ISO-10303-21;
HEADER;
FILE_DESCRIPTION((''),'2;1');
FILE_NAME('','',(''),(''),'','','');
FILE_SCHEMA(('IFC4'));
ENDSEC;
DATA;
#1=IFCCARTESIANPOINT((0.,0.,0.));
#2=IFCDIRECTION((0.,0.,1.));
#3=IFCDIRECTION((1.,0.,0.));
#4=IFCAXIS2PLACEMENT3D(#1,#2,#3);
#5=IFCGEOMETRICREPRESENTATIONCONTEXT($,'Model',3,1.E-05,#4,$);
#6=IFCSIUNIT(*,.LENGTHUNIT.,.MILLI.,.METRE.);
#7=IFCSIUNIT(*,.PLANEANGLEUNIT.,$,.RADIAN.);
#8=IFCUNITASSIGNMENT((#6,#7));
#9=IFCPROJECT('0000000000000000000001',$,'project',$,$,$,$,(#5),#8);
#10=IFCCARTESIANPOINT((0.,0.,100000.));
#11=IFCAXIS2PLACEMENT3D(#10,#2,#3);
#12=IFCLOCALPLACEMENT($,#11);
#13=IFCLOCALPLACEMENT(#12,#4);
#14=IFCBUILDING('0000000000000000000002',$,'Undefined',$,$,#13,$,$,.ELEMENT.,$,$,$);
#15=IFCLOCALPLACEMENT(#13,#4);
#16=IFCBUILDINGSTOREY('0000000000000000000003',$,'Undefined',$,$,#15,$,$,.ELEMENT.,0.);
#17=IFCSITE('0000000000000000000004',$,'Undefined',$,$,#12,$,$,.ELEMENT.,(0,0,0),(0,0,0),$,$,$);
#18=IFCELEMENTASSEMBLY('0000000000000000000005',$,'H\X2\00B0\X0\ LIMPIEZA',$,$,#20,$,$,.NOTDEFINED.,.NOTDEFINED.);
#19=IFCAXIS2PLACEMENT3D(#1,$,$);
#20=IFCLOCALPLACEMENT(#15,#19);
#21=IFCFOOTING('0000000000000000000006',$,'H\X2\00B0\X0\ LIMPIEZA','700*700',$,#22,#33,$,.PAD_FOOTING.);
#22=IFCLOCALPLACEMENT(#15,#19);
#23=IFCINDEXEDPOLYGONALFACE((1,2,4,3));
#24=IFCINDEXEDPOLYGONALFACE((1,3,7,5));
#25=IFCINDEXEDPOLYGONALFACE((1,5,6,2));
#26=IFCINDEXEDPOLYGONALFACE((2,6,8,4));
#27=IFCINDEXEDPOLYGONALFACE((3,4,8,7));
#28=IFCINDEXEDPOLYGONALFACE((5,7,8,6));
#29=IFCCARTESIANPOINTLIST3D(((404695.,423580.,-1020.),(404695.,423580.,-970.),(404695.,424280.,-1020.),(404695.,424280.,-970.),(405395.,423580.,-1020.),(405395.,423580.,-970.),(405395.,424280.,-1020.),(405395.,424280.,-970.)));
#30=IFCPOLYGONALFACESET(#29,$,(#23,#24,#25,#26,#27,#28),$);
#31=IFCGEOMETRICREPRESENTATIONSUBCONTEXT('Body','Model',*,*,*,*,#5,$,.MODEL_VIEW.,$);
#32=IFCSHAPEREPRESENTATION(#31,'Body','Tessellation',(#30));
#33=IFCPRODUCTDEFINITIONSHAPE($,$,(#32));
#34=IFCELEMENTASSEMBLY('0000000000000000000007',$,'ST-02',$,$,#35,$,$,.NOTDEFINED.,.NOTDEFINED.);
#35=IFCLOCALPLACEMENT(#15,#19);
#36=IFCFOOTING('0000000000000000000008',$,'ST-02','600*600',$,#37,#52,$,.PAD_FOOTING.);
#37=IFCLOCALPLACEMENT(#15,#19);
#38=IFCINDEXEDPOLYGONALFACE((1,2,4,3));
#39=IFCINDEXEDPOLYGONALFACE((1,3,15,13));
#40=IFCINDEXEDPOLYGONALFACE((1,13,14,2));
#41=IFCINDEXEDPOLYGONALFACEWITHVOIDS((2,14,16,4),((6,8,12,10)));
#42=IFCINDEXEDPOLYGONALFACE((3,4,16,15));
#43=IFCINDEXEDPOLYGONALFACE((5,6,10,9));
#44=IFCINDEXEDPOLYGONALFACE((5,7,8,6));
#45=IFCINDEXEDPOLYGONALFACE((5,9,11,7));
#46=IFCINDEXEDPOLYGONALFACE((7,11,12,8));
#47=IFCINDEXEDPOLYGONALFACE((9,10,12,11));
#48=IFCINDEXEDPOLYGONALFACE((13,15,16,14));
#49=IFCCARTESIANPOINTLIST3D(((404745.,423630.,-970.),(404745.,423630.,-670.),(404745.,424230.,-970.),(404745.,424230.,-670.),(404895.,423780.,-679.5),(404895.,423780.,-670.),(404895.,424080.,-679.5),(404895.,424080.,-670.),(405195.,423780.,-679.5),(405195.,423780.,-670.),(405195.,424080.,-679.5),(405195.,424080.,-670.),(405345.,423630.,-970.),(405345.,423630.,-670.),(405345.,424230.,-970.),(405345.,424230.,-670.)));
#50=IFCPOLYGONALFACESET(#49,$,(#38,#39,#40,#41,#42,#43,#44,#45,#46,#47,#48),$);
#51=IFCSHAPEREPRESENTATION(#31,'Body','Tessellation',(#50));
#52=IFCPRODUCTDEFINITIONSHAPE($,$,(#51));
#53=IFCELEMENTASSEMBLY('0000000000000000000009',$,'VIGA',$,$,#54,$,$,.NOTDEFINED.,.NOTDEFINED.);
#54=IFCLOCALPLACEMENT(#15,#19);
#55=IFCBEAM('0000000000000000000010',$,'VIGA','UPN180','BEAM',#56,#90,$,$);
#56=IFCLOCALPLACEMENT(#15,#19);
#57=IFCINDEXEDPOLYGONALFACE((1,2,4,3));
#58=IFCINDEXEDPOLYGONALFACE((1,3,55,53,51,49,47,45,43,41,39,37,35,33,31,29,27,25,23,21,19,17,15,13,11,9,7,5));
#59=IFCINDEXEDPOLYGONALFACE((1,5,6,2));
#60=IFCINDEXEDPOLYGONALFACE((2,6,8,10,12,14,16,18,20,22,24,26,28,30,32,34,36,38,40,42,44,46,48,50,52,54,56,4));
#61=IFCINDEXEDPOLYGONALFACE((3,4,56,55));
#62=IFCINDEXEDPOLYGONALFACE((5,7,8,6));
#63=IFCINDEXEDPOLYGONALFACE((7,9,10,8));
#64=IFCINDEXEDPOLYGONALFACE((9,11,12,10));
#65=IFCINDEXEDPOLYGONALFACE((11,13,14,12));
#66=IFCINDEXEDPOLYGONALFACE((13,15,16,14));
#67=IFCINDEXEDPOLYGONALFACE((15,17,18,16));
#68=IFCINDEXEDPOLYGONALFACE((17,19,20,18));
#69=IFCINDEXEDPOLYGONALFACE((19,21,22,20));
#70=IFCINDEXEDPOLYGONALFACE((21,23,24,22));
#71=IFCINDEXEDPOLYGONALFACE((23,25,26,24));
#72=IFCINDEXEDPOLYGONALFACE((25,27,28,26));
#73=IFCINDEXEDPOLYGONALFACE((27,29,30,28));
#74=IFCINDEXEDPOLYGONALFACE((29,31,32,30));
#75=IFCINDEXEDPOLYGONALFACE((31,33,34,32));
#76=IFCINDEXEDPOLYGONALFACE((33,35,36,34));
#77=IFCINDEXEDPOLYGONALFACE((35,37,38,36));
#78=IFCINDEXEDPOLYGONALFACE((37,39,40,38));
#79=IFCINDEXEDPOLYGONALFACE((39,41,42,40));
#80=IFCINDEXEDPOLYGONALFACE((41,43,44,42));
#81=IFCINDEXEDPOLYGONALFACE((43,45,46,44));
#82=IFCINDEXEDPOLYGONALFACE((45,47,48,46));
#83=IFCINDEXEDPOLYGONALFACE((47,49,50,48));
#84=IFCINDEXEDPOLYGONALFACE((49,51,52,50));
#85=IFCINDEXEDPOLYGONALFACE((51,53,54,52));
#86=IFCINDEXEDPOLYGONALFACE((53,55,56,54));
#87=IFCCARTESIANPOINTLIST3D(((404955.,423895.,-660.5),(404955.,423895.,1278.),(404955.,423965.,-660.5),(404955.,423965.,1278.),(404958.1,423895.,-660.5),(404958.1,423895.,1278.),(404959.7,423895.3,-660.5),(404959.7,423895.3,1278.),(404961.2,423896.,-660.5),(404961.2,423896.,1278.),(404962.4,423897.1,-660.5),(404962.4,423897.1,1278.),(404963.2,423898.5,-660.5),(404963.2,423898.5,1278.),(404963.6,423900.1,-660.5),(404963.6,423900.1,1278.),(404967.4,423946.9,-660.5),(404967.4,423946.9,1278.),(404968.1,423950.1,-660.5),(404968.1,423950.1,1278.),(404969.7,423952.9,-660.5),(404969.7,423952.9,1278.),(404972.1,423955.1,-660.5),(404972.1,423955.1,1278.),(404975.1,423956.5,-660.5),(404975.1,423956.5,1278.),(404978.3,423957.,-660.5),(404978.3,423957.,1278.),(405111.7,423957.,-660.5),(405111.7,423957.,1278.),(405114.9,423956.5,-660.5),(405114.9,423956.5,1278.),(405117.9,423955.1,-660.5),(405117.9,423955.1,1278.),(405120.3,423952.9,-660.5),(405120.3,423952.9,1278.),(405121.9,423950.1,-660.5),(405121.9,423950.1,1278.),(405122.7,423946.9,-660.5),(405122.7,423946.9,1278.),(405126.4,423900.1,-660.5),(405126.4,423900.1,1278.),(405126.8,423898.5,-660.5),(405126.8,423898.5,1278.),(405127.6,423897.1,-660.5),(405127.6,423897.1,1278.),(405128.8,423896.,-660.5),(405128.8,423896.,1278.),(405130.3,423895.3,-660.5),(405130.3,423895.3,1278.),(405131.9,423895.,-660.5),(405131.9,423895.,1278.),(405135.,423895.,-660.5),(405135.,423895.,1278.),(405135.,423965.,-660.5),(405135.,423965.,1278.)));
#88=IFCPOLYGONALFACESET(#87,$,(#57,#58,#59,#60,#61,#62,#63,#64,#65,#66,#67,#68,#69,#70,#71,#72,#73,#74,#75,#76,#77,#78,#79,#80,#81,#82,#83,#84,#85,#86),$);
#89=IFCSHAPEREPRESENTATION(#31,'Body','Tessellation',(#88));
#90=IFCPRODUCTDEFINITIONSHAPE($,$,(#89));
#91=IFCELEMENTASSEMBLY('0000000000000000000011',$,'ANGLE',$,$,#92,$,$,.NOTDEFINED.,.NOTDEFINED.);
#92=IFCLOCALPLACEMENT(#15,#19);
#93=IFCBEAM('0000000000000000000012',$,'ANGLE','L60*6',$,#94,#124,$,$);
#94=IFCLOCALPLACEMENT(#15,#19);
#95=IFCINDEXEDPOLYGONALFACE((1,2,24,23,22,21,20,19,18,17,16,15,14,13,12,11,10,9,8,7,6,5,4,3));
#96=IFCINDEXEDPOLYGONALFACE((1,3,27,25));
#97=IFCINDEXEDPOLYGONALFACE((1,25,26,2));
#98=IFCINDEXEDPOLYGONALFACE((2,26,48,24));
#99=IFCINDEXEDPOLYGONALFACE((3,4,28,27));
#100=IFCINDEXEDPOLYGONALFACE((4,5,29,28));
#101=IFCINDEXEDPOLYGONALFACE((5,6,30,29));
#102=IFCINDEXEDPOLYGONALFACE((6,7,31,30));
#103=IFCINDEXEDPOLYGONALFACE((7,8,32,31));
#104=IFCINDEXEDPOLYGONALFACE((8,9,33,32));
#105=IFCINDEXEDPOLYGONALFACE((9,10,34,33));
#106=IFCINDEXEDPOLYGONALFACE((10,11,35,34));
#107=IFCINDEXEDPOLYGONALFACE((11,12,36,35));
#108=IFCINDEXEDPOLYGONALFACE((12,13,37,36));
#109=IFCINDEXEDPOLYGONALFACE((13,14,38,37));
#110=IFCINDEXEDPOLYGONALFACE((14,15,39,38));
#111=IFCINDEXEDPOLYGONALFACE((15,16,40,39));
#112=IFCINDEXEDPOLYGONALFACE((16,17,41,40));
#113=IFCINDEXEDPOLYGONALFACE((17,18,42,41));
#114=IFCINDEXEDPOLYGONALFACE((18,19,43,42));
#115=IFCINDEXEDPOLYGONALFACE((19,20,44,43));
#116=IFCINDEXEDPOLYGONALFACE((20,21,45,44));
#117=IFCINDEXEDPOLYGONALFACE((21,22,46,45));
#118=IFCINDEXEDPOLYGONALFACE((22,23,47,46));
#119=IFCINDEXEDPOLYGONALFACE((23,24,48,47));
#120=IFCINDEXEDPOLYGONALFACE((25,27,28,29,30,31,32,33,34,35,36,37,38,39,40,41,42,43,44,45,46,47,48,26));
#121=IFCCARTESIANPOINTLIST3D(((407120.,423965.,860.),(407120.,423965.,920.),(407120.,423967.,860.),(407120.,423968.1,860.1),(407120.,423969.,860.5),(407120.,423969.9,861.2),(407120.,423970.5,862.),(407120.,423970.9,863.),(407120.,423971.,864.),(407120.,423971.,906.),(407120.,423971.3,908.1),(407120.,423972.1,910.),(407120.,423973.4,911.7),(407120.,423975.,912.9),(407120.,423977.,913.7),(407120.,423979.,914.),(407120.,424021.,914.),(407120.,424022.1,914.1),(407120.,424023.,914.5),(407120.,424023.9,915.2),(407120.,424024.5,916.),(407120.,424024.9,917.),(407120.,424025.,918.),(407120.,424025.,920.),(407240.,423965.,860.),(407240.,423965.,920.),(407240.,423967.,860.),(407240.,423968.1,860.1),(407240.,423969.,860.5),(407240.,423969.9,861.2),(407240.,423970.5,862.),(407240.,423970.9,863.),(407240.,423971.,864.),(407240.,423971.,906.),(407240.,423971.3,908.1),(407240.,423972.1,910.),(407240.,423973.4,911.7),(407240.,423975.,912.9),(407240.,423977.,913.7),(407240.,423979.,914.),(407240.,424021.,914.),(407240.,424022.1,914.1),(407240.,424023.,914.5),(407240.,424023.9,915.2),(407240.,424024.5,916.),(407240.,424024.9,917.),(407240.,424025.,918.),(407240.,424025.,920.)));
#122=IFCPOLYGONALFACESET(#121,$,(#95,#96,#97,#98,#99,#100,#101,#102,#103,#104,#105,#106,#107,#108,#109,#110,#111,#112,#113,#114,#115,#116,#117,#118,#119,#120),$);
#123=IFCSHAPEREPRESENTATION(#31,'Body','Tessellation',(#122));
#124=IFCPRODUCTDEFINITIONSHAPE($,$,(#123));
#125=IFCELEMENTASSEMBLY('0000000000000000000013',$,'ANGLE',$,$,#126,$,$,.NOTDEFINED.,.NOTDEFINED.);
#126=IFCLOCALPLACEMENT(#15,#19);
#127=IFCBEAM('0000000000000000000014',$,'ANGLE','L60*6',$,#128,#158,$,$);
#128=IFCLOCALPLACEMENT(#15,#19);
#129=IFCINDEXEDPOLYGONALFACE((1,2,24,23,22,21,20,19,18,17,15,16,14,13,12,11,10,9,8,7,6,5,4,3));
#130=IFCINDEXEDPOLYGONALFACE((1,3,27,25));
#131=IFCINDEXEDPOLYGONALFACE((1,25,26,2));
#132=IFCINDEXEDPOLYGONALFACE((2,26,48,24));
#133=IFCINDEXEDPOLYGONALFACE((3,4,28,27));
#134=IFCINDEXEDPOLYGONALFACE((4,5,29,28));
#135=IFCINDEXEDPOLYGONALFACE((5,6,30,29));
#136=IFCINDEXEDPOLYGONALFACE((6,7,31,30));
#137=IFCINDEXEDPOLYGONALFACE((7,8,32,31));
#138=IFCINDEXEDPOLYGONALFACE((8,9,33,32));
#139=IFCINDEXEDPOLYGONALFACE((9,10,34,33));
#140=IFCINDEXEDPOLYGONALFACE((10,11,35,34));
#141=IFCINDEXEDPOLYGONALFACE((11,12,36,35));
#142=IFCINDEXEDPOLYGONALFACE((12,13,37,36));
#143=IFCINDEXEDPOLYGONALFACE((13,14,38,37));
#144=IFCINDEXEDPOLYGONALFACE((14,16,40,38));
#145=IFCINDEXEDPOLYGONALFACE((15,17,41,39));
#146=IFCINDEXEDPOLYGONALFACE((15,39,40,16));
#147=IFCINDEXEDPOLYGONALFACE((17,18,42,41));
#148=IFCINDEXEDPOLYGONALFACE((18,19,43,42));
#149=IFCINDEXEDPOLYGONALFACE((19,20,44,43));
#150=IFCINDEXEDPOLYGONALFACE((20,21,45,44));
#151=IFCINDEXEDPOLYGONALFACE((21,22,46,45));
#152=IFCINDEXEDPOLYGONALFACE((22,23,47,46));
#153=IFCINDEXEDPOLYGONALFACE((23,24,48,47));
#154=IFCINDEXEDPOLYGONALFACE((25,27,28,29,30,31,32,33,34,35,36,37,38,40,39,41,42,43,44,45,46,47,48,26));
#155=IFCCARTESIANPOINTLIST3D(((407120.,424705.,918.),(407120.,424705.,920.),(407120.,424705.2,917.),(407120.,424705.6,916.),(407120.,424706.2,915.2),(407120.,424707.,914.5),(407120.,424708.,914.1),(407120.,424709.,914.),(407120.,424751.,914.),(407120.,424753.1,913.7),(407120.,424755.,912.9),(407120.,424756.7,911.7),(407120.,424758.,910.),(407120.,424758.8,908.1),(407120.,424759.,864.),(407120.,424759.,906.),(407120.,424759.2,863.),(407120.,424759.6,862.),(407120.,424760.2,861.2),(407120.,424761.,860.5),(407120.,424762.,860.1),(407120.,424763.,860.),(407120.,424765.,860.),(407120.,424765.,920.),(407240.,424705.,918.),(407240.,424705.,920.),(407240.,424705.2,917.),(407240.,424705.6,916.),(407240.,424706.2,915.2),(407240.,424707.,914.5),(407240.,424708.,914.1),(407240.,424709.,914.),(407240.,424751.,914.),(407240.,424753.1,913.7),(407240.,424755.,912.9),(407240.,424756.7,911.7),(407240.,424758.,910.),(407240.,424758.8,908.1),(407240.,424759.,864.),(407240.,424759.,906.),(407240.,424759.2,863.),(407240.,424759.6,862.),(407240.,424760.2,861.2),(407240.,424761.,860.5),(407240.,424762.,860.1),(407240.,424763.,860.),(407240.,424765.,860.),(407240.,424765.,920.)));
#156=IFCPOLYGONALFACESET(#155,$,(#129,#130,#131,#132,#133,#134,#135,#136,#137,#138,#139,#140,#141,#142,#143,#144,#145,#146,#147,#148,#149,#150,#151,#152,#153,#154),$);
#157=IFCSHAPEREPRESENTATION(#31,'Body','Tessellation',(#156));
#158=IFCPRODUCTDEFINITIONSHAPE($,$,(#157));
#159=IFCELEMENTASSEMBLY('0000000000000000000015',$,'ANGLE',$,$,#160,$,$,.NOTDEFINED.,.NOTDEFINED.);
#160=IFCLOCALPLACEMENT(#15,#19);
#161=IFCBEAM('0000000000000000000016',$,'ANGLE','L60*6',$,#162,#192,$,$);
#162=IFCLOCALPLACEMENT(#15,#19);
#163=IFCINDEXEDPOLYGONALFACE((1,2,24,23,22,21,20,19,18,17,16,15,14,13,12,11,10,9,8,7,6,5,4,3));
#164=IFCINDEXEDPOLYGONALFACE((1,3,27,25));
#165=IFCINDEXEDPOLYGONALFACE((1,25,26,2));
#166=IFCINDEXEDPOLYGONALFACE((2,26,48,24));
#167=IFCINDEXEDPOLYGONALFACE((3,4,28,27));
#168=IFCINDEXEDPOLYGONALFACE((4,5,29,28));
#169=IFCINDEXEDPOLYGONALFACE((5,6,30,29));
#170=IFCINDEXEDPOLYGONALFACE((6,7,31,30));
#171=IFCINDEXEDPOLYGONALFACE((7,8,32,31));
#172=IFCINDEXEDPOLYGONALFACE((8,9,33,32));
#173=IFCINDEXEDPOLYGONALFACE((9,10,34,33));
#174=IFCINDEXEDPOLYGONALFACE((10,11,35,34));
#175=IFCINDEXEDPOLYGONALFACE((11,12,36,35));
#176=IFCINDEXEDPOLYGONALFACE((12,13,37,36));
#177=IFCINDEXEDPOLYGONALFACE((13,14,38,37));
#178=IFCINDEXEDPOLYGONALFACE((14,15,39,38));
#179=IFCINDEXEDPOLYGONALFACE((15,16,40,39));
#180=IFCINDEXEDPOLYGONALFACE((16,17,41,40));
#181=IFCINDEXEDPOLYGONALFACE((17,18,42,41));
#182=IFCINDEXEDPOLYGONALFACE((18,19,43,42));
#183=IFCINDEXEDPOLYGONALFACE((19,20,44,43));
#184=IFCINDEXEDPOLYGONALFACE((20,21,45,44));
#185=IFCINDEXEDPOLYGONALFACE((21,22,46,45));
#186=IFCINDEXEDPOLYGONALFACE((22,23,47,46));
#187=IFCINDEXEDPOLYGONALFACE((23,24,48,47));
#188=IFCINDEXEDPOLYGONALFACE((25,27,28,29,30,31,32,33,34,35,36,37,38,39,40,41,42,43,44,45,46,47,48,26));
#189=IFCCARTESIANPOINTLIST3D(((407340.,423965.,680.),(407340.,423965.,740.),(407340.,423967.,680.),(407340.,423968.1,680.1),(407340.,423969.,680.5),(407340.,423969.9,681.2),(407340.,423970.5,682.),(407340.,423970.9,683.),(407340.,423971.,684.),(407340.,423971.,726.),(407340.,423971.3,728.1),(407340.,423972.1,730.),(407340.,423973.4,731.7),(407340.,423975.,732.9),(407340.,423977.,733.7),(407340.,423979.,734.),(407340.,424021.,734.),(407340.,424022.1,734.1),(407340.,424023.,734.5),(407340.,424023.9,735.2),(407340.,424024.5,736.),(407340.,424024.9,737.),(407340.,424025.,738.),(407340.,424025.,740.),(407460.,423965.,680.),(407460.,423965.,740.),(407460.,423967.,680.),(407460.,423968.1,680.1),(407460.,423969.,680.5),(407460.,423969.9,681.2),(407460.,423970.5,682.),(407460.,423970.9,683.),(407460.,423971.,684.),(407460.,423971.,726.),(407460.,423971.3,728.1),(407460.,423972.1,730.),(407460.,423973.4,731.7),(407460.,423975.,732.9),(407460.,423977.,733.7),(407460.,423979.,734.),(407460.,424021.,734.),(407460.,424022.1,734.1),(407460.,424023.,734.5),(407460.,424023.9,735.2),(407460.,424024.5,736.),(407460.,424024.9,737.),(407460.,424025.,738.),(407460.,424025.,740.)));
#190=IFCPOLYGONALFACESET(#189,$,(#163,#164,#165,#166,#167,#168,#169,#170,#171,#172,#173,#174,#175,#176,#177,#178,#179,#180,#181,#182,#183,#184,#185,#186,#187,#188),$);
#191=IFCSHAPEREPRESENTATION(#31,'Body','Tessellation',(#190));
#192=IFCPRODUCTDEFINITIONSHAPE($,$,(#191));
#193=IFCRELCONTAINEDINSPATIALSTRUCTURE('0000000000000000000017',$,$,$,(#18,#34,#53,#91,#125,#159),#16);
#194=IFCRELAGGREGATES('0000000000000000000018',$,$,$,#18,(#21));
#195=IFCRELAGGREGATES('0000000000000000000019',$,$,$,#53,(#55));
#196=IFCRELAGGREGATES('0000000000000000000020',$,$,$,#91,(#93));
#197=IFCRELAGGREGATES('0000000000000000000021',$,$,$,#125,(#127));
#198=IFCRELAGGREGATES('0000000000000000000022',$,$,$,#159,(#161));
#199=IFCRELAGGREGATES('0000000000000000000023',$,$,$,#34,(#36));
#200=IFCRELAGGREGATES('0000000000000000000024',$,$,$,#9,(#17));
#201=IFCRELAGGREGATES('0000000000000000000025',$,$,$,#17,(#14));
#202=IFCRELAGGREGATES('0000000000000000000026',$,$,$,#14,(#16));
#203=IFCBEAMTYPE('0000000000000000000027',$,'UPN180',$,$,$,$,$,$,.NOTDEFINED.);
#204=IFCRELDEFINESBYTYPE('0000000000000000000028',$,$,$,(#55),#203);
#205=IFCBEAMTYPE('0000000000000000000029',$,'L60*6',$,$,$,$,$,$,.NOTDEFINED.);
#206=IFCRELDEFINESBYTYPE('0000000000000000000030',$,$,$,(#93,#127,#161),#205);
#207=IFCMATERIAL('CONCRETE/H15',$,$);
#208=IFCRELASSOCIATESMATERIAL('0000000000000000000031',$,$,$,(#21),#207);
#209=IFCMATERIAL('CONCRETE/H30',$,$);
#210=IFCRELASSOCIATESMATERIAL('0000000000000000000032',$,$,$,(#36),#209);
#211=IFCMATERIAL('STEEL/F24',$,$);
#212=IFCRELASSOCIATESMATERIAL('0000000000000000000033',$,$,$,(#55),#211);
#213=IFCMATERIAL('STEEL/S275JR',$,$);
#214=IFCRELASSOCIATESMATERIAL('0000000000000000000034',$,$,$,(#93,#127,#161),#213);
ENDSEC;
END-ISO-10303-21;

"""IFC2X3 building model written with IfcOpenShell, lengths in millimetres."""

from ifc_helpers import new_model, si_unit, frame, origin_with_axes, origin_2d_with_axis, place, context, subcontext, project, spatial, polyline, rectangle, l_section, u_section, outline, extrude, boolean, material, type_object, element, aggregate, save


model = new_model("IFC2X3")

# Units and contexts
model_context = context("Model", 3, precision=1e-05, world=origin_with_axes())
body_context = subcontext(model_context, "Body", "Model", "MODEL_VIEW")
ifc_project = project(units=[si_unit("LENGTHUNIT", "METRE", prefix="MILLI"), si_unit("PLANEANGLEUNIT", "RADIAN")], contexts=[model_context])

# Site, building, storey
site_placement = place(None, frame((0.0, 0.0, 100000.0), z_axis=(0.0, 0.0, 1.0), x_axis=(1.0, 0.0, 0.0)))
site = spatial("IfcSite", under=ifc_project, at=site_placement, Name="Undefined", CompositionType="ELEMENT", RefLatitude=(0, 0, 0), RefLongitude=(0, 0, 0))
building_placement = place(site_placement, origin_with_axes())
building = spatial("IfcBuilding", under=site, at=building_placement, Name="Undefined", CompositionType="ELEMENT")
storey_placement = place(building_placement, origin_with_axes())
storey = spatial("IfcBuildingStorey", under=building, at=storey_placement, Name="Undefined", CompositionType="ELEMENT", Elevation=0.0)

# Element assemblies, footings
assembly_1_placement = place(storey_placement, origin_with_axes())
assembly_1 = element("IfcElementAssembly", 1, at=assembly_1_placement, inside=storey, Name="H° LIMPIEZA", AssemblyPlace="NOTDEFINED", PredefinedType="NOTDEFINED")
ifc_material_1 = material(Name="CONCRETE/H15")
footing_1_placement = place(assembly_1_placement, frame((405045.0, 423930.0, -1020.0), z_axis=(0.0, 1.0, 0.0), x_axis=(0.0, 0.0, 1.0)))
footing_1 = element("IfcFooting", 2, at=footing_1_placement, material=ifc_material_1, Name="H° LIMPIEZA", Description="700*700", PredefinedType="PAD_FOOTING", context=body_context, shape_type="SweptSolid", body=[
    extrude(rectangle(XDim=700.0, YDim=700.0, at=origin_2d_with_axis()), frame((50.0, 0.0, 0.0), z_axis=(-1.0, 0.0, 0.0), x_axis=(0.0, -1.0, 0.0)), (0.0, 0.0, 1.0), 50.0),
])
aggregate(assembly_1, [footing_1])
assembly_2_placement = place(storey_placement, origin_with_axes())
assembly_2 = element("IfcElementAssembly", 3, at=assembly_2_placement, inside=storey, Name="ST-02", AssemblyPlace="NOTDEFINED", PredefinedType="NOTDEFINED")
ifc_material_2 = material(Name="CONCRETE/H30")
footing_2_placement = place(assembly_2_placement, frame((405045.0, 423930.0, -970.0), z_axis=(0.0, 1.0, 0.0), x_axis=(0.0, 0.0, 1.0)))
footing_2 = element("IfcFooting", 4, at=footing_2_placement, material=ifc_material_2, Name="ST-02", Description="600*600", PredefinedType="PAD_FOOTING", context=body_context, shape_type="CSG", body=[
    boolean("DIFFERENCE", extrude(rectangle(XDim=600.0, YDim=600.0, at=origin_2d_with_axis()), frame((300.0, 0.0, 0.0), z_axis=(-1.0, 0.0, 0.0), x_axis=(0.0, -1.0, 0.0)), (0.0, 0.0, 1.0), 300.0), extrude(outline(polyline([(0.0, 0.0), (300.0, 0.0), (300.0, 300.0), (0.0, 300.0), (0.0, 0.0)])), frame((290.5, -150.0, -150.0), z_axis=(1.0, 0.0, 0.0), x_axis=(0.0, 1.0, 0.0)), (0.0, 0.0, 1.0), 19.1)),
])

# Shared definitions
ifc_material_3 = material(Name="STEEL/F24")

# Element assemblies, beams
assembly_3_placement = place(storey_placement, origin_with_axes())
assembly_3 = element("IfcElementAssembly", 5, at=assembly_3_placement, inside=storey, Name="VIGA", AssemblyPlace="NOTDEFINED", PredefinedType="NOTDEFINED")
beam_type_1 = type_object("IfcBeamType", Name="UPN180", PredefinedType="NOTDEFINED")
beam_1_placement = place(assembly_3_placement, frame((405045.0, 423930.0, -660.5), z_axis=(-1.0, 0.0, 0.0), x_axis=(0.0, 0.0, 1.0)))
beam_1 = element("IfcBeam", 6, at=beam_1_placement, type_object=beam_type_1, material=ifc_material_3, Name="VIGA", Description="UPN180", ObjectType="BEAM", context=body_context, shape_type="SweptSolid", body=[
    extrude(u_section(Depth=180.0, FlangeWidth=70.0, WebThickness=8.0, FlangeThickness=11.0, FilletRadius=11.0, EdgeRadius=5.5, FlangeSlope=0.07983, at=origin_2d_with_axis()), frame((1938.5, 0.0, 0.0), z_axis=(-1.0, 0.0, 0.0), x_axis=(0.0, -1.0, 0.0)), (0.0, 0.0, 1.0), 1938.5),
])
aggregate(assembly_3, [beam_1])
assembly_4_placement = place(storey_placement, origin_with_axes())
assembly_4 = element("IfcElementAssembly", 7, at=assembly_4_placement, inside=storey, Name="ANGLE", AssemblyPlace="NOTDEFINED", PredefinedType="NOTDEFINED")
ifc_material_4 = material(Name="STEEL/S275JR")
beam_type_2 = type_object("IfcBeamType", Name="L60*6", PredefinedType="NOTDEFINED")
beam_2_placement = place(assembly_4_placement, frame((407240.0, 423995.0, 890.0), z_axis=(0.0, 1.0, 0.0), x_axis=(-1.0, 0.0, 0.0)))
beam_2 = element("IfcBeam", 8, at=beam_2_placement, type_object=beam_type_2, material=ifc_material_4, Name="ANGLE", Description="L60*6", context=body_context, shape_type="SweptSolid", body=[
    extrude(l_section(Depth=60.0, Width=60.0, Thickness=6.0, FilletRadius=8.0, EdgeRadius=4.0, at=origin_2d_with_axis()), frame((120.0, 0.0, 0.0), z_axis=(-1.0, 0.0, 0.0), x_axis=(0.0, -1.0, 0.0)), (0.0, 0.0, 1.0), 120.0),
])
assembly_5_placement = place(storey_placement, origin_with_axes())
assembly_5 = element("IfcElementAssembly", 9, at=assembly_5_placement, inside=storey, Name="ANGLE", AssemblyPlace="NOTDEFINED", PredefinedType="NOTDEFINED")
beam_3_placement = place(assembly_5_placement, frame((407120.0, 424735.0, 890.0), z_axis=(0.0, -1.0, 0.0), x_axis=(1.0, 0.0, 0.0)))
beam_3 = element("IfcBeam", 10, at=beam_3_placement, type_object=beam_type_2, material=ifc_material_4, Name="ANGLE", Description="L60*6", context=body_context, shape_type="SweptSolid", body=[
    extrude(l_section(Depth=60.0, Width=60.0, Thickness=6.0, FilletRadius=8.0, EdgeRadius=4.0, at=origin_2d_with_axis()), frame((120.0, 0.0, 0.0), z_axis=(-1.0, 0.0, 0.0), x_axis=(0.0, -1.0, 0.0)), (0.0, 0.0, 1.0), 120.0),
])
assembly_6_placement = place(storey_placement, origin_with_axes())
assembly_6 = element("IfcElementAssembly", 11, at=assembly_6_placement, inside=storey, Name="ANGLE", AssemblyPlace="NOTDEFINED", PredefinedType="NOTDEFINED")
beam_4_placement = place(assembly_6_placement, frame((407460.0, 423995.0, 710.0), z_axis=(0.0, 1.0, 0.0), x_axis=(-1.0, 0.0, 0.0)))
beam_4 = element("IfcBeam", 12, at=beam_4_placement, type_object=beam_type_2, material=ifc_material_4, Name="ANGLE", Description="L60*6", context=body_context, shape_type="SweptSolid", body=[
    extrude(l_section(Depth=60.0, Width=60.0, Thickness=6.0, FilletRadius=8.0, EdgeRadius=4.0, at=origin_2d_with_axis()), frame((120.0, 0.0, 0.0), z_axis=(-1.0, 0.0, 0.0), x_axis=(0.0, -1.0, 0.0)), (0.0, 0.0, 1.0), 120.0),
])

aggregate(assembly_4, [beam_2])
aggregate(assembly_5, [beam_3])
aggregate(assembly_6, [beam_4])

aggregate(assembly_2, [footing_2])

save(model, "model.ifc")
